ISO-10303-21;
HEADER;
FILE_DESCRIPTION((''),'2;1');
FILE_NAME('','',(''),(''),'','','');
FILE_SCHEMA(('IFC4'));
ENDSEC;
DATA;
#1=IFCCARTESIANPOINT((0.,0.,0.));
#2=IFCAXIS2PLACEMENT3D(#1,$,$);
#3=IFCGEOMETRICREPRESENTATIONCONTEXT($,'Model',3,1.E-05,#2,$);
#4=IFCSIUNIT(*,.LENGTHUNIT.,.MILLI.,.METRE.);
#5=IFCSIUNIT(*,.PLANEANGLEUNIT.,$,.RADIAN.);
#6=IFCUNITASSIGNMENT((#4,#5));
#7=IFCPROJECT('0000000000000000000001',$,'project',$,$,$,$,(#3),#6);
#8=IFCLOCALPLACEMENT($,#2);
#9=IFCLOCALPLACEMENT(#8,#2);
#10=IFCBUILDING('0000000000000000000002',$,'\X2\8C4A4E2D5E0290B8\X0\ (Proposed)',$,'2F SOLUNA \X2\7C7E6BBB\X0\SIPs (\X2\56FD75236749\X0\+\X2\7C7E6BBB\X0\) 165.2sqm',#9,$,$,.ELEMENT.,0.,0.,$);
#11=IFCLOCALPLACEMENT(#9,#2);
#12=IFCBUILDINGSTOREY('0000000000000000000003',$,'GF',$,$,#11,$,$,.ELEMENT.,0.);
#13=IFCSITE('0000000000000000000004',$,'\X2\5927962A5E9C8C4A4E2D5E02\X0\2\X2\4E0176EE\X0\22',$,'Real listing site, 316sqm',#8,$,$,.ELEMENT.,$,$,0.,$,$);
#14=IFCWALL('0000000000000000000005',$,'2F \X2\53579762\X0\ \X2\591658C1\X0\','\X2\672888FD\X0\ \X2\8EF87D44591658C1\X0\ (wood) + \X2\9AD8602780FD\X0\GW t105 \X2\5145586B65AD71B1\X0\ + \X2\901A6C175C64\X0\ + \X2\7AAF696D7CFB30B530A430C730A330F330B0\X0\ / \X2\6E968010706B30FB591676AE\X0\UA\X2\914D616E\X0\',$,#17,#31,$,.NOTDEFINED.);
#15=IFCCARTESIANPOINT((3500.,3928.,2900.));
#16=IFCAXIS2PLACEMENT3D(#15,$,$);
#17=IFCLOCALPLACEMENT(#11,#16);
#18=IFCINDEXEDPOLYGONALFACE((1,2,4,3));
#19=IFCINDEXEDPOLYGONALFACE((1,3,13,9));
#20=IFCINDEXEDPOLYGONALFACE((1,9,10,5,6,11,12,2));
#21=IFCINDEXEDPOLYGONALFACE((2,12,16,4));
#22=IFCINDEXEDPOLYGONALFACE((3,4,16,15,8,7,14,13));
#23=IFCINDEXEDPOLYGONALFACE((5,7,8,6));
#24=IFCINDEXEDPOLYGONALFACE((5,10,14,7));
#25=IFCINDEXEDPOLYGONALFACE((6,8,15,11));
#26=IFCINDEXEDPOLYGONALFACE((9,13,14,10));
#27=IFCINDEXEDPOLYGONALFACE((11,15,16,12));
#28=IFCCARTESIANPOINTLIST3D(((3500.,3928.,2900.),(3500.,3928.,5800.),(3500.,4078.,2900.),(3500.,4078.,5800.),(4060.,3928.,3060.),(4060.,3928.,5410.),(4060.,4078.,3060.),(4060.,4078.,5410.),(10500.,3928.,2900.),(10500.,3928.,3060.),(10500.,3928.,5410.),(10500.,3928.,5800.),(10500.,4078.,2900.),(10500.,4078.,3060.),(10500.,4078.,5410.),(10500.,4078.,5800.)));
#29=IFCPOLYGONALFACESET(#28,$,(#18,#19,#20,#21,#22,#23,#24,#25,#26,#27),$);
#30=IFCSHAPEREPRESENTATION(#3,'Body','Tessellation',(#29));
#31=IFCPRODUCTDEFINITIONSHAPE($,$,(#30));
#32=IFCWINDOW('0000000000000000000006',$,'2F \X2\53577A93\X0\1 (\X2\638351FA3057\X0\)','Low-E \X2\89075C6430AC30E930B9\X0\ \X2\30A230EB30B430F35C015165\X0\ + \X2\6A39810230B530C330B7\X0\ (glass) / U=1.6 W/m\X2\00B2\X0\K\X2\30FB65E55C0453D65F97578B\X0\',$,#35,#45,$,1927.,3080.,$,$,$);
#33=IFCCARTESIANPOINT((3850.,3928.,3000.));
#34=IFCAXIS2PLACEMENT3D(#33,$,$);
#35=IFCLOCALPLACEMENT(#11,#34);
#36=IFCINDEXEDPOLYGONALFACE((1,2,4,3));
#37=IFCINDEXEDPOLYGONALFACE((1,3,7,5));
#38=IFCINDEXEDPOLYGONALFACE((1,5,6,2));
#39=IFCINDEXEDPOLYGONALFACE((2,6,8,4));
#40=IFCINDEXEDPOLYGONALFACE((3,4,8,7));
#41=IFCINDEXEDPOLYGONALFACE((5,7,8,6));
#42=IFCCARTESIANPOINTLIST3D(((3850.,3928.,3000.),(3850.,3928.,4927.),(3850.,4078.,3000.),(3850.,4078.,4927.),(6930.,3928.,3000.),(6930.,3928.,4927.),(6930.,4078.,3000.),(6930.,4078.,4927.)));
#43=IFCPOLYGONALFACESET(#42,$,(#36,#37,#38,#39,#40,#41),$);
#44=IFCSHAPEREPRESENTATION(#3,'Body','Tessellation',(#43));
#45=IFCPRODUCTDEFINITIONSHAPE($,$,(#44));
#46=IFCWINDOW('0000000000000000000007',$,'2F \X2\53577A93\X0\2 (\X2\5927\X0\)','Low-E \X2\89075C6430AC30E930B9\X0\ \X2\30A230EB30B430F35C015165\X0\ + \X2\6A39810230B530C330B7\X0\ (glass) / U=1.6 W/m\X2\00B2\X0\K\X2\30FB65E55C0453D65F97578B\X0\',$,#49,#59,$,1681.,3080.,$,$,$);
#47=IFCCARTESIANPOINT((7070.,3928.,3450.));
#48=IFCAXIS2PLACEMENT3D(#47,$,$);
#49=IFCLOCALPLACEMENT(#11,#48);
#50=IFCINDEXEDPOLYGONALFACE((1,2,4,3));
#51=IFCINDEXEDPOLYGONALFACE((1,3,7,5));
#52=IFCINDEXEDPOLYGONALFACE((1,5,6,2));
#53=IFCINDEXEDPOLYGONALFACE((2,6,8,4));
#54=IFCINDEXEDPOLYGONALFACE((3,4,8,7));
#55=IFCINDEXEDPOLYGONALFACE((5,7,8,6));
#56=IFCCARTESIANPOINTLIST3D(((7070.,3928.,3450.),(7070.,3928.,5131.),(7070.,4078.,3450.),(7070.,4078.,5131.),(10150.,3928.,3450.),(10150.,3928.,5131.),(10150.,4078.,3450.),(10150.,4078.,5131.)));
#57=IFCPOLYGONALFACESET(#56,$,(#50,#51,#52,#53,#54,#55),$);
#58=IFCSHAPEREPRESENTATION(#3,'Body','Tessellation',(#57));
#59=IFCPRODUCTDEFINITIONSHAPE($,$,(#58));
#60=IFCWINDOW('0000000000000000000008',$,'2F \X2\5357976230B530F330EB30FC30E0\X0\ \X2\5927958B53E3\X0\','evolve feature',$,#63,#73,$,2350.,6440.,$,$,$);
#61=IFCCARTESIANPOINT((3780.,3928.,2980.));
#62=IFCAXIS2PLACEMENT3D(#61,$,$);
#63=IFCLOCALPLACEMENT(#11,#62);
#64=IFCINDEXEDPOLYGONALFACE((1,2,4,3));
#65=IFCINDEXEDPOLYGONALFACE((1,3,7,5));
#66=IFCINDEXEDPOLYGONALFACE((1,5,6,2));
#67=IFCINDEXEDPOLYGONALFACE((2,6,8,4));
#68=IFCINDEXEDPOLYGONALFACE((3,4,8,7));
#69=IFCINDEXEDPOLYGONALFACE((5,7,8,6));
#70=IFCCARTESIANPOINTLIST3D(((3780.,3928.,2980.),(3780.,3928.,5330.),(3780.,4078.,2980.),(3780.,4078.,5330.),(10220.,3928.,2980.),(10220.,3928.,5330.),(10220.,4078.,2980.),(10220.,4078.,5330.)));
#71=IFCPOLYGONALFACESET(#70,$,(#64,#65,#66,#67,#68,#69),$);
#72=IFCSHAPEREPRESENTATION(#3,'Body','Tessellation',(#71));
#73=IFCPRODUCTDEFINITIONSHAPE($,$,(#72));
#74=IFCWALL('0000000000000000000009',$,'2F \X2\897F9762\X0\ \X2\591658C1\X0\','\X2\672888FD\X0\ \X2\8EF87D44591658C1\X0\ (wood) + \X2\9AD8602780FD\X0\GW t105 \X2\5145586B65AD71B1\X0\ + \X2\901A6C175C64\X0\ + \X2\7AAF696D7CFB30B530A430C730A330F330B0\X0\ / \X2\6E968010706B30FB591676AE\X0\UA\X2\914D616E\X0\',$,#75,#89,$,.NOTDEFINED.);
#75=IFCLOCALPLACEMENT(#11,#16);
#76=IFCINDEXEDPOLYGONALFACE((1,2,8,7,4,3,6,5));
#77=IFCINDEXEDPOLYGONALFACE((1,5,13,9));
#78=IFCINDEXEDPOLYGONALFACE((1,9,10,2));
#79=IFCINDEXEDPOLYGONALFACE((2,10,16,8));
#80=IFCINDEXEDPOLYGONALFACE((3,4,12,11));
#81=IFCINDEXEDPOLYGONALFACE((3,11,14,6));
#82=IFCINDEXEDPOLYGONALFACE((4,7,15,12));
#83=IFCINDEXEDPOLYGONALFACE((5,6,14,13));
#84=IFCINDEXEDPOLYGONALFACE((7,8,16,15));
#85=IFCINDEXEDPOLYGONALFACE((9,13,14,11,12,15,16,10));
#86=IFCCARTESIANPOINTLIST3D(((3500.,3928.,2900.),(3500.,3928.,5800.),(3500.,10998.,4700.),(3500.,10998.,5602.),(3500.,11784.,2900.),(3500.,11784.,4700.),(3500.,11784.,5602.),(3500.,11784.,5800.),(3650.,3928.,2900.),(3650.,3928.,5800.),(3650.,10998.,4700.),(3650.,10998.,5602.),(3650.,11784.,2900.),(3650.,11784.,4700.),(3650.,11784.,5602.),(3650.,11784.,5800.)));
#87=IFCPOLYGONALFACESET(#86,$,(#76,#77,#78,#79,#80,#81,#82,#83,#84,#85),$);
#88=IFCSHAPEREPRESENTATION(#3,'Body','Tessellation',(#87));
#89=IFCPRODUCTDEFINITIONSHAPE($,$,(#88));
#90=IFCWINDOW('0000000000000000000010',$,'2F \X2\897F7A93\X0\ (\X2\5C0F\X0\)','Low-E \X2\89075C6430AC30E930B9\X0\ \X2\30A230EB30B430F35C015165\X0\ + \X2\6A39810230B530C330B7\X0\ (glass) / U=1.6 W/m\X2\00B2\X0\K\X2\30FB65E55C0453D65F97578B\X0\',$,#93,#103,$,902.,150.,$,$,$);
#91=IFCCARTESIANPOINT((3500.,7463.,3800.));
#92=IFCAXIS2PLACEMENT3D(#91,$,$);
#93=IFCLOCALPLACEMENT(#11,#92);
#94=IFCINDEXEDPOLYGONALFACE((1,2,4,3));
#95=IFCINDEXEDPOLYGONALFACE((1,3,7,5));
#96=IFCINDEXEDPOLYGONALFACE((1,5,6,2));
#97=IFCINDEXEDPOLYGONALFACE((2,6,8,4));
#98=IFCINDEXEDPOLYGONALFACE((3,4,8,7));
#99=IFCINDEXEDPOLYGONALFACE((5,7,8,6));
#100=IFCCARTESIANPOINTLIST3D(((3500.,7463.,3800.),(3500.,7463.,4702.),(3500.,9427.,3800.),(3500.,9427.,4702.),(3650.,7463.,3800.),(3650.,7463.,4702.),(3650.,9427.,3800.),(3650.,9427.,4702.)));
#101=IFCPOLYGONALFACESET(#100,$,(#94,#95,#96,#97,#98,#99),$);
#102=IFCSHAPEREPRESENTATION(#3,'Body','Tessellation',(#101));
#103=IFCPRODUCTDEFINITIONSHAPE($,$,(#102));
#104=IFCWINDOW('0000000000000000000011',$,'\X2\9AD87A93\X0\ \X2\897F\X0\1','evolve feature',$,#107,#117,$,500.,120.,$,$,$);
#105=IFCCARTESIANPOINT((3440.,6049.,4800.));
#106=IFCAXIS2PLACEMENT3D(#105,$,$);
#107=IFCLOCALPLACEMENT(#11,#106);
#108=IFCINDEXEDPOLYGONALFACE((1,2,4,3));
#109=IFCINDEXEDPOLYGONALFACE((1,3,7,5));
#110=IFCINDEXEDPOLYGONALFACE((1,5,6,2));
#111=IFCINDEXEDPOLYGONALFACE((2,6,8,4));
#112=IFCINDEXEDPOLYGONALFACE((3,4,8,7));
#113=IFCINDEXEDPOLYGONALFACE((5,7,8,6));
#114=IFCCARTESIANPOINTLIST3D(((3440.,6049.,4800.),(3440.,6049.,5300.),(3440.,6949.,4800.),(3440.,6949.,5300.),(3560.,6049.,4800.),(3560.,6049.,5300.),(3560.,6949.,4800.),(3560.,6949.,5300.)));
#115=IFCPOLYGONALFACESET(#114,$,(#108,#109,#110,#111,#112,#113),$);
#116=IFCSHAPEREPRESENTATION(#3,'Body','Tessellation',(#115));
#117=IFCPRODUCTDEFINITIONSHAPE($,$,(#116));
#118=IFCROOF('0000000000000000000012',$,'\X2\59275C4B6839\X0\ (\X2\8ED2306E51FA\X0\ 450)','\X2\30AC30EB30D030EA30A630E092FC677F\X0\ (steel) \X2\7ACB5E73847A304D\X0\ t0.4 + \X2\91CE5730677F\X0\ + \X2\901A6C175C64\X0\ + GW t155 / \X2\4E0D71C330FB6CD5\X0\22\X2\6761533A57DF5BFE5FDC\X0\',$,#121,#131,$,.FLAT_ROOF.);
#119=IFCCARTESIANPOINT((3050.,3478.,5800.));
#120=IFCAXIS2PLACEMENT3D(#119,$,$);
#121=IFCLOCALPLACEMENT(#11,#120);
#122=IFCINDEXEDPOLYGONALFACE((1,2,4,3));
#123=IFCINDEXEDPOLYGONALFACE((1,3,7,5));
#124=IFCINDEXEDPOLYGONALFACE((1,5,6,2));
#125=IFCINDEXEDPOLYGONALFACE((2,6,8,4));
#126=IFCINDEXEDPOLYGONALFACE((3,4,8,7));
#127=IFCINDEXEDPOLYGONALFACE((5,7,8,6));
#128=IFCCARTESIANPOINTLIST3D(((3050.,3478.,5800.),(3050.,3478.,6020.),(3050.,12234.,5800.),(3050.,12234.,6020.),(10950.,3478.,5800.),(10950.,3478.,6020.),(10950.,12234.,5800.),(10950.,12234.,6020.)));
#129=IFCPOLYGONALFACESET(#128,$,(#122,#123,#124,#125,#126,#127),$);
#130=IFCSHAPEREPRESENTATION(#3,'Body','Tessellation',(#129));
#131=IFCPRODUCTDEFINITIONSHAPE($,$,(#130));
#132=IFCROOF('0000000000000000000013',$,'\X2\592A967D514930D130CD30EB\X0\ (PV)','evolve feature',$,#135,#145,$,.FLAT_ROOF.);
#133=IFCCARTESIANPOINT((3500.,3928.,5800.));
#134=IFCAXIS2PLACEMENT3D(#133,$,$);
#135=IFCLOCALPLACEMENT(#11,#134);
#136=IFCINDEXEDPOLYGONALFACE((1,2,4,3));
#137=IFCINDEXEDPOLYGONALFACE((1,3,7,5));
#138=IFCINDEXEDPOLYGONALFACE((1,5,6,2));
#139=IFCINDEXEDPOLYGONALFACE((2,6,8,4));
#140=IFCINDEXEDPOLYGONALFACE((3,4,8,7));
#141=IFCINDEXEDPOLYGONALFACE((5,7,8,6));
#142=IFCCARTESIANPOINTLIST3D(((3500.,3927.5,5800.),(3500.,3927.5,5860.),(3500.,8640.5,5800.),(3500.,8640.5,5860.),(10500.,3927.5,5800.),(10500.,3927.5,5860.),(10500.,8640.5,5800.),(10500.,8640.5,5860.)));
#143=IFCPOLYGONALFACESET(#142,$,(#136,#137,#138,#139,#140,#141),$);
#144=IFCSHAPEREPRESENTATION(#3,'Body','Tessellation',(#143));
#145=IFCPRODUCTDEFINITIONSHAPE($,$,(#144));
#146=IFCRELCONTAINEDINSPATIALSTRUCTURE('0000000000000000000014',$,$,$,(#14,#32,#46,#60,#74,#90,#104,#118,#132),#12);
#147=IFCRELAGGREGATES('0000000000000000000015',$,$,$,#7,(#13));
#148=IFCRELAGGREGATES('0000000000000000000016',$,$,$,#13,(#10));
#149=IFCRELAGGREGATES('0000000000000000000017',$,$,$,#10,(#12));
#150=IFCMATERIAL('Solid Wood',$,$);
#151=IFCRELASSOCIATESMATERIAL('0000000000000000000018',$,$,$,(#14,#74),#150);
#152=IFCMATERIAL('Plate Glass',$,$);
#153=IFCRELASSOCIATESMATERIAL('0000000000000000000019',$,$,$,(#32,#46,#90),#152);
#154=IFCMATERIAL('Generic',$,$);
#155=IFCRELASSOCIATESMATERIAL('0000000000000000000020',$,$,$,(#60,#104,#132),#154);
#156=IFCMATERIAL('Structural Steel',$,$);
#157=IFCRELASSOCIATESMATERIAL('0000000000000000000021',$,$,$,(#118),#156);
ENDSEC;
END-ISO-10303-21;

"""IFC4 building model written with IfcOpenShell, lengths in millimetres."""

from ifc_helpers import new_model, si_unit, frame, frame_2d, origin, place, context, project, spatial, rectangle, extrude, material, element, fill, save


model = new_model("IFC4")

# Units and contexts
model_context = context("Model", 3, precision=1e-05, world=origin())
ifc_project = project(units=[si_unit("LENGTHUNIT", "METRE", prefix="MILLI"), si_unit("PLANEANGLEUNIT", "RADIAN")], contexts=[model_context])

# Site, building, storey
site_placement = place(None, origin())
site = spatial("IfcSite", under=ifc_project, at=site_placement, Name="大阪府豊中市2丁目22", ObjectType="Real listing site, 316sqm", CompositionType="ELEMENT", RefElevation=0.0)
building_placement = place(site_placement, origin())
building = spatial("IfcBuilding", under=site, at=building_placement, Name="豊中市邸 (Proposed)", ObjectType="2F SOLUNA 籾殻SIPs (国産杉+籾殻) 165.2sqm", CompositionType="ELEMENT", ElevationOfRefHeight=0.0, ElevationOfTerrain=0.0)
storey_placement = place(building_placement, origin())
storey = spatial("IfcBuildingStorey", under=building, at=storey_placement, Name="GF", CompositionType="ELEMENT", Elevation=0.0)

# Shared definitions
ifc_material_1 = material(Name="Solid Wood")
ifc_material_2 = material(Name="Generic")

# Shared definitions
ifc_material_3 = material(Name="Plate Glass")

# Walls, openings, windows
wall_1_placement = place(storey_placement, frame((3500.0, 3928.0, 2900.0)))
wall_1 = element("IfcWall", 1, at=wall_1_placement, inside=storey, material=ifc_material_1, Name="2F 南面 外壁", Description="木製 軸組外壁 (wood) + 高性能GW t105 充填断熱 + 通気層 + 窯業系サイディング / 準耐火・外皮UA配慮", PredefinedType="NOTDEFINED", context=model_context, shape_type="SweptSolid", body=[
    extrude(rectangle(XDim=7000.0, YDim=150.0, at=frame_2d((3500.0, 75.0))), frame((3500.0, 3928.0, 2900.0)), (0.0, 0.0, 1.0), 2900.0),
])
opening_1_placement = place(storey_placement, frame((3850.0, 3928.0, 3000.0)))
opening_1 = element("IfcOpeningElement", 2, at=opening_1_placement, cuts=wall_1, PredefinedType="NOTDEFINED", context=model_context, shape_type="SweptSolid", body=[
    extrude(rectangle(XDim=3080.0, YDim=150.0, at=frame_2d((1540.0, 75.0))), frame((3850.0, 3928.0, 3000.0)), (0.0, 0.0, 1.0), 1927.0),
])
opening_2_placement = place(storey_placement, frame((7070.0, 3928.0, 3450.0)))
opening_2 = element("IfcOpeningElement", 3, at=opening_2_placement, cuts=wall_1, PredefinedType="NOTDEFINED", context=model_context, shape_type="SweptSolid", body=[
    extrude(rectangle(XDim=3080.0, YDim=150.0, at=frame_2d((1540.0, 75.0))), frame((7070.0, 3928.0, 3450.0)), (0.0, 0.0, 1.0), 1681.0),
])
opening_3_placement = place(storey_placement, frame((3780.0, 3928.0, 2980.0)))
opening_3 = element("IfcOpeningElement", 4, at=opening_3_placement, cuts=wall_1, PredefinedType="NOTDEFINED", context=model_context, shape_type="SweptSolid", body=[
    extrude(rectangle(XDim=6440.0, YDim=150.0, at=frame_2d((3220.0, 75.0))), frame((3780.0, 3928.0, 2980.0)), (0.0, 0.0, 1.0), 2350.0),
])
window_1_placement = place(storey_placement, frame((3850.0, 3928.0, 3000.0)))
window_1 = element("IfcWindow", 5, at=window_1_placement, inside=storey, material=ifc_material_3, Name="2F 南窓1 (掃出し)", Description="Low-E 複層ガラス アルゴン封入 + 樹脂サッシ (glass) / U=1.6 W/m²K・日射取得型", OverallHeight=1927.0, OverallWidth=3080.0, context=model_context, shape_type="SweptSolid", body=[
    extrude(rectangle(XDim=3080.0, YDim=150.0, at=frame_2d((1540.0, 75.0))), frame((3850.0, 3928.0, 3000.0)), (0.0, 0.0, 1.0), 1927.0),
])
fill(opening_1, window_1)
window_2_placement = place(storey_placement, frame((7070.0, 3928.0, 3450.0)))
window_2 = element("IfcWindow", 6, at=window_2_placement, inside=storey, material=ifc_material_3, Name="2F 南窓2 (大)", Description="Low-E 複層ガラス アルゴン封入 + 樹脂サッシ (glass) / U=1.6 W/m²K・日射取得型", OverallHeight=1681.0, OverallWidth=3080.0, context=model_context, shape_type="SweptSolid", body=[
    extrude(rectangle(XDim=3080.0, YDim=150.0, at=frame_2d((1540.0, 75.0))), frame((7070.0, 3928.0, 3450.0)), (0.0, 0.0, 1.0), 1681.0),
])
fill(opening_2, window_2)
window_3_placement = place(storey_placement, frame((3780.0, 3928.0, 2980.0)))
window_3 = element("IfcWindow", 7, at=window_3_placement, inside=storey, material=ifc_material_2, Name="2F 南面サンルーム 大開口", Description="evolve feature", OverallHeight=2350.0, OverallWidth=6440.0, context=model_context, shape_type="SweptSolid", body=[
    extrude(rectangle(XDim=6440.0, YDim=150.0, at=frame_2d((3220.0, 75.0))), frame((3780.0, 3928.0, 2980.0)), (0.0, 0.0, 1.0), 2350.0),
])
fill(opening_3, window_3)
wall_2_placement = place(storey_placement, frame((3500.0, 3928.0, 2900.0)))
wall_2 = element("IfcWall", 8, at=wall_2_placement, inside=storey, material=ifc_material_1, Name="2F 西面 外壁", Description="木製 軸組外壁 (wood) + 高性能GW t105 充填断熱 + 通気層 + 窯業系サイディング / 準耐火・外皮UA配慮", PredefinedType="NOTDEFINED", context=model_context, shape_type="SweptSolid", body=[
    extrude(rectangle(XDim=150.0, YDim=7856.0, at=frame_2d((75.0, 3928.0))), frame((3500.0, 3928.0, 2900.0)), (0.0, 0.0, 1.0), 2900.0),
])
opening_4_placement = place(storey_placement, frame((3500.0, 7463.0, 3800.0)))
opening_4 = element("IfcOpeningElement", 9, at=opening_4_placement, cuts=wall_2, PredefinedType="NOTDEFINED", context=model_context, shape_type="SweptSolid", body=[
    extrude(rectangle(XDim=150.0, YDim=1964.0, at=frame_2d((75.0, 982.0))), frame((3500.0, 7463.0, 3800.0)), (0.0, 0.0, 1.0), 902.0),
])
opening_5_placement = place(storey_placement, frame((3440.0, 6049.0, 4800.0)))
opening_5 = element("IfcOpeningElement", 10, at=opening_5_placement, cuts=wall_2, PredefinedType="NOTDEFINED", context=model_context, shape_type="SweptSolid", body=[
    extrude(rectangle(XDim=120.0, YDim=900.0, at=frame_2d((60.0, 450.0))), frame((3440.0, 6049.0, 4800.0)), (0.0, 0.0, 1.0), 500.0),
])
window_4_placement = place(storey_placement, frame((3500.0, 7463.0, 3800.0)))
window_4 = element("IfcWindow", 11, at=window_4_placement, inside=storey, material=ifc_material_3, Name="2F 西窓 (小)", Description="Low-E 複層ガラス アルゴン封入 + 樹脂サッシ (glass) / U=1.6 W/m²K・日射取得型", OverallHeight=902.0, OverallWidth=150.0, context=model_context, shape_type="SweptSolid", body=[
    extrude(rectangle(XDim=150.0, YDim=1964.0, at=frame_2d((75.0, 982.0))), frame((3500.0, 7463.0, 3800.0)), (0.0, 0.0, 1.0), 902.0),
])
fill(opening_4, window_4)
window_5_placement = place(storey_placement, frame((3440.0, 6049.0, 4800.0)))
window_5 = element("IfcWindow", 12, at=window_5_placement, inside=storey, material=ifc_material_2, Name="高窓 西1", Description="evolve feature", OverallHeight=500.0, OverallWidth=120.0, context=model_context, shape_type="SweptSolid", body=[
    extrude(rectangle(XDim=120.0, YDim=900.0, at=frame_2d((60.0, 450.0))), frame((3440.0, 6049.0, 4800.0)), (0.0, 0.0, 1.0), 500.0),
])
fill(opening_5, window_5)

# Roofs
ifc_material_4 = material(Name="Structural Steel")
roof_1_placement = place(storey_placement, frame((3050.0, 3478.0, 5800.0)))
element("IfcRoof", 13, at=roof_1_placement, inside=storey, material=ifc_material_4, Name="大屋根 (軒の出 450)", Description="ガルバリウム鋼板 (steel) 立平葺き t0.4 + 野地板 + 通気層 + GW t155 / 不燃・法22条区域対応", PredefinedType="FLAT_ROOF", context=model_context, shape_type="SweptSolid", body=[
    extrude(rectangle(XDim=7900.0, YDim=8756.0, at=frame_2d((3950.0, 4378.0))), frame((3050.0, 3478.0, 5800.0)), (0.0, 0.0, 1.0), 220.0),
])
roof_2_placement = place(storey_placement, frame((3500.0, 3928.0, 5800.0)))
element("IfcRoof", 14, at=roof_2_placement, inside=storey, material=ifc_material_2, Name="太陽光パネル (PV)", Description="evolve feature", PredefinedType="FLAT_ROOF", context=model_context, shape_type="SweptSolid", body=[
    extrude(rectangle(XDim=7000.0, YDim=4713.0, at=frame_2d((3500.0, 2356.0))), frame((3500.0, 3928.0, 5800.0)), (0.0, 0.0, 1.0), 60.0),
])

save(model, "model.ifc")
